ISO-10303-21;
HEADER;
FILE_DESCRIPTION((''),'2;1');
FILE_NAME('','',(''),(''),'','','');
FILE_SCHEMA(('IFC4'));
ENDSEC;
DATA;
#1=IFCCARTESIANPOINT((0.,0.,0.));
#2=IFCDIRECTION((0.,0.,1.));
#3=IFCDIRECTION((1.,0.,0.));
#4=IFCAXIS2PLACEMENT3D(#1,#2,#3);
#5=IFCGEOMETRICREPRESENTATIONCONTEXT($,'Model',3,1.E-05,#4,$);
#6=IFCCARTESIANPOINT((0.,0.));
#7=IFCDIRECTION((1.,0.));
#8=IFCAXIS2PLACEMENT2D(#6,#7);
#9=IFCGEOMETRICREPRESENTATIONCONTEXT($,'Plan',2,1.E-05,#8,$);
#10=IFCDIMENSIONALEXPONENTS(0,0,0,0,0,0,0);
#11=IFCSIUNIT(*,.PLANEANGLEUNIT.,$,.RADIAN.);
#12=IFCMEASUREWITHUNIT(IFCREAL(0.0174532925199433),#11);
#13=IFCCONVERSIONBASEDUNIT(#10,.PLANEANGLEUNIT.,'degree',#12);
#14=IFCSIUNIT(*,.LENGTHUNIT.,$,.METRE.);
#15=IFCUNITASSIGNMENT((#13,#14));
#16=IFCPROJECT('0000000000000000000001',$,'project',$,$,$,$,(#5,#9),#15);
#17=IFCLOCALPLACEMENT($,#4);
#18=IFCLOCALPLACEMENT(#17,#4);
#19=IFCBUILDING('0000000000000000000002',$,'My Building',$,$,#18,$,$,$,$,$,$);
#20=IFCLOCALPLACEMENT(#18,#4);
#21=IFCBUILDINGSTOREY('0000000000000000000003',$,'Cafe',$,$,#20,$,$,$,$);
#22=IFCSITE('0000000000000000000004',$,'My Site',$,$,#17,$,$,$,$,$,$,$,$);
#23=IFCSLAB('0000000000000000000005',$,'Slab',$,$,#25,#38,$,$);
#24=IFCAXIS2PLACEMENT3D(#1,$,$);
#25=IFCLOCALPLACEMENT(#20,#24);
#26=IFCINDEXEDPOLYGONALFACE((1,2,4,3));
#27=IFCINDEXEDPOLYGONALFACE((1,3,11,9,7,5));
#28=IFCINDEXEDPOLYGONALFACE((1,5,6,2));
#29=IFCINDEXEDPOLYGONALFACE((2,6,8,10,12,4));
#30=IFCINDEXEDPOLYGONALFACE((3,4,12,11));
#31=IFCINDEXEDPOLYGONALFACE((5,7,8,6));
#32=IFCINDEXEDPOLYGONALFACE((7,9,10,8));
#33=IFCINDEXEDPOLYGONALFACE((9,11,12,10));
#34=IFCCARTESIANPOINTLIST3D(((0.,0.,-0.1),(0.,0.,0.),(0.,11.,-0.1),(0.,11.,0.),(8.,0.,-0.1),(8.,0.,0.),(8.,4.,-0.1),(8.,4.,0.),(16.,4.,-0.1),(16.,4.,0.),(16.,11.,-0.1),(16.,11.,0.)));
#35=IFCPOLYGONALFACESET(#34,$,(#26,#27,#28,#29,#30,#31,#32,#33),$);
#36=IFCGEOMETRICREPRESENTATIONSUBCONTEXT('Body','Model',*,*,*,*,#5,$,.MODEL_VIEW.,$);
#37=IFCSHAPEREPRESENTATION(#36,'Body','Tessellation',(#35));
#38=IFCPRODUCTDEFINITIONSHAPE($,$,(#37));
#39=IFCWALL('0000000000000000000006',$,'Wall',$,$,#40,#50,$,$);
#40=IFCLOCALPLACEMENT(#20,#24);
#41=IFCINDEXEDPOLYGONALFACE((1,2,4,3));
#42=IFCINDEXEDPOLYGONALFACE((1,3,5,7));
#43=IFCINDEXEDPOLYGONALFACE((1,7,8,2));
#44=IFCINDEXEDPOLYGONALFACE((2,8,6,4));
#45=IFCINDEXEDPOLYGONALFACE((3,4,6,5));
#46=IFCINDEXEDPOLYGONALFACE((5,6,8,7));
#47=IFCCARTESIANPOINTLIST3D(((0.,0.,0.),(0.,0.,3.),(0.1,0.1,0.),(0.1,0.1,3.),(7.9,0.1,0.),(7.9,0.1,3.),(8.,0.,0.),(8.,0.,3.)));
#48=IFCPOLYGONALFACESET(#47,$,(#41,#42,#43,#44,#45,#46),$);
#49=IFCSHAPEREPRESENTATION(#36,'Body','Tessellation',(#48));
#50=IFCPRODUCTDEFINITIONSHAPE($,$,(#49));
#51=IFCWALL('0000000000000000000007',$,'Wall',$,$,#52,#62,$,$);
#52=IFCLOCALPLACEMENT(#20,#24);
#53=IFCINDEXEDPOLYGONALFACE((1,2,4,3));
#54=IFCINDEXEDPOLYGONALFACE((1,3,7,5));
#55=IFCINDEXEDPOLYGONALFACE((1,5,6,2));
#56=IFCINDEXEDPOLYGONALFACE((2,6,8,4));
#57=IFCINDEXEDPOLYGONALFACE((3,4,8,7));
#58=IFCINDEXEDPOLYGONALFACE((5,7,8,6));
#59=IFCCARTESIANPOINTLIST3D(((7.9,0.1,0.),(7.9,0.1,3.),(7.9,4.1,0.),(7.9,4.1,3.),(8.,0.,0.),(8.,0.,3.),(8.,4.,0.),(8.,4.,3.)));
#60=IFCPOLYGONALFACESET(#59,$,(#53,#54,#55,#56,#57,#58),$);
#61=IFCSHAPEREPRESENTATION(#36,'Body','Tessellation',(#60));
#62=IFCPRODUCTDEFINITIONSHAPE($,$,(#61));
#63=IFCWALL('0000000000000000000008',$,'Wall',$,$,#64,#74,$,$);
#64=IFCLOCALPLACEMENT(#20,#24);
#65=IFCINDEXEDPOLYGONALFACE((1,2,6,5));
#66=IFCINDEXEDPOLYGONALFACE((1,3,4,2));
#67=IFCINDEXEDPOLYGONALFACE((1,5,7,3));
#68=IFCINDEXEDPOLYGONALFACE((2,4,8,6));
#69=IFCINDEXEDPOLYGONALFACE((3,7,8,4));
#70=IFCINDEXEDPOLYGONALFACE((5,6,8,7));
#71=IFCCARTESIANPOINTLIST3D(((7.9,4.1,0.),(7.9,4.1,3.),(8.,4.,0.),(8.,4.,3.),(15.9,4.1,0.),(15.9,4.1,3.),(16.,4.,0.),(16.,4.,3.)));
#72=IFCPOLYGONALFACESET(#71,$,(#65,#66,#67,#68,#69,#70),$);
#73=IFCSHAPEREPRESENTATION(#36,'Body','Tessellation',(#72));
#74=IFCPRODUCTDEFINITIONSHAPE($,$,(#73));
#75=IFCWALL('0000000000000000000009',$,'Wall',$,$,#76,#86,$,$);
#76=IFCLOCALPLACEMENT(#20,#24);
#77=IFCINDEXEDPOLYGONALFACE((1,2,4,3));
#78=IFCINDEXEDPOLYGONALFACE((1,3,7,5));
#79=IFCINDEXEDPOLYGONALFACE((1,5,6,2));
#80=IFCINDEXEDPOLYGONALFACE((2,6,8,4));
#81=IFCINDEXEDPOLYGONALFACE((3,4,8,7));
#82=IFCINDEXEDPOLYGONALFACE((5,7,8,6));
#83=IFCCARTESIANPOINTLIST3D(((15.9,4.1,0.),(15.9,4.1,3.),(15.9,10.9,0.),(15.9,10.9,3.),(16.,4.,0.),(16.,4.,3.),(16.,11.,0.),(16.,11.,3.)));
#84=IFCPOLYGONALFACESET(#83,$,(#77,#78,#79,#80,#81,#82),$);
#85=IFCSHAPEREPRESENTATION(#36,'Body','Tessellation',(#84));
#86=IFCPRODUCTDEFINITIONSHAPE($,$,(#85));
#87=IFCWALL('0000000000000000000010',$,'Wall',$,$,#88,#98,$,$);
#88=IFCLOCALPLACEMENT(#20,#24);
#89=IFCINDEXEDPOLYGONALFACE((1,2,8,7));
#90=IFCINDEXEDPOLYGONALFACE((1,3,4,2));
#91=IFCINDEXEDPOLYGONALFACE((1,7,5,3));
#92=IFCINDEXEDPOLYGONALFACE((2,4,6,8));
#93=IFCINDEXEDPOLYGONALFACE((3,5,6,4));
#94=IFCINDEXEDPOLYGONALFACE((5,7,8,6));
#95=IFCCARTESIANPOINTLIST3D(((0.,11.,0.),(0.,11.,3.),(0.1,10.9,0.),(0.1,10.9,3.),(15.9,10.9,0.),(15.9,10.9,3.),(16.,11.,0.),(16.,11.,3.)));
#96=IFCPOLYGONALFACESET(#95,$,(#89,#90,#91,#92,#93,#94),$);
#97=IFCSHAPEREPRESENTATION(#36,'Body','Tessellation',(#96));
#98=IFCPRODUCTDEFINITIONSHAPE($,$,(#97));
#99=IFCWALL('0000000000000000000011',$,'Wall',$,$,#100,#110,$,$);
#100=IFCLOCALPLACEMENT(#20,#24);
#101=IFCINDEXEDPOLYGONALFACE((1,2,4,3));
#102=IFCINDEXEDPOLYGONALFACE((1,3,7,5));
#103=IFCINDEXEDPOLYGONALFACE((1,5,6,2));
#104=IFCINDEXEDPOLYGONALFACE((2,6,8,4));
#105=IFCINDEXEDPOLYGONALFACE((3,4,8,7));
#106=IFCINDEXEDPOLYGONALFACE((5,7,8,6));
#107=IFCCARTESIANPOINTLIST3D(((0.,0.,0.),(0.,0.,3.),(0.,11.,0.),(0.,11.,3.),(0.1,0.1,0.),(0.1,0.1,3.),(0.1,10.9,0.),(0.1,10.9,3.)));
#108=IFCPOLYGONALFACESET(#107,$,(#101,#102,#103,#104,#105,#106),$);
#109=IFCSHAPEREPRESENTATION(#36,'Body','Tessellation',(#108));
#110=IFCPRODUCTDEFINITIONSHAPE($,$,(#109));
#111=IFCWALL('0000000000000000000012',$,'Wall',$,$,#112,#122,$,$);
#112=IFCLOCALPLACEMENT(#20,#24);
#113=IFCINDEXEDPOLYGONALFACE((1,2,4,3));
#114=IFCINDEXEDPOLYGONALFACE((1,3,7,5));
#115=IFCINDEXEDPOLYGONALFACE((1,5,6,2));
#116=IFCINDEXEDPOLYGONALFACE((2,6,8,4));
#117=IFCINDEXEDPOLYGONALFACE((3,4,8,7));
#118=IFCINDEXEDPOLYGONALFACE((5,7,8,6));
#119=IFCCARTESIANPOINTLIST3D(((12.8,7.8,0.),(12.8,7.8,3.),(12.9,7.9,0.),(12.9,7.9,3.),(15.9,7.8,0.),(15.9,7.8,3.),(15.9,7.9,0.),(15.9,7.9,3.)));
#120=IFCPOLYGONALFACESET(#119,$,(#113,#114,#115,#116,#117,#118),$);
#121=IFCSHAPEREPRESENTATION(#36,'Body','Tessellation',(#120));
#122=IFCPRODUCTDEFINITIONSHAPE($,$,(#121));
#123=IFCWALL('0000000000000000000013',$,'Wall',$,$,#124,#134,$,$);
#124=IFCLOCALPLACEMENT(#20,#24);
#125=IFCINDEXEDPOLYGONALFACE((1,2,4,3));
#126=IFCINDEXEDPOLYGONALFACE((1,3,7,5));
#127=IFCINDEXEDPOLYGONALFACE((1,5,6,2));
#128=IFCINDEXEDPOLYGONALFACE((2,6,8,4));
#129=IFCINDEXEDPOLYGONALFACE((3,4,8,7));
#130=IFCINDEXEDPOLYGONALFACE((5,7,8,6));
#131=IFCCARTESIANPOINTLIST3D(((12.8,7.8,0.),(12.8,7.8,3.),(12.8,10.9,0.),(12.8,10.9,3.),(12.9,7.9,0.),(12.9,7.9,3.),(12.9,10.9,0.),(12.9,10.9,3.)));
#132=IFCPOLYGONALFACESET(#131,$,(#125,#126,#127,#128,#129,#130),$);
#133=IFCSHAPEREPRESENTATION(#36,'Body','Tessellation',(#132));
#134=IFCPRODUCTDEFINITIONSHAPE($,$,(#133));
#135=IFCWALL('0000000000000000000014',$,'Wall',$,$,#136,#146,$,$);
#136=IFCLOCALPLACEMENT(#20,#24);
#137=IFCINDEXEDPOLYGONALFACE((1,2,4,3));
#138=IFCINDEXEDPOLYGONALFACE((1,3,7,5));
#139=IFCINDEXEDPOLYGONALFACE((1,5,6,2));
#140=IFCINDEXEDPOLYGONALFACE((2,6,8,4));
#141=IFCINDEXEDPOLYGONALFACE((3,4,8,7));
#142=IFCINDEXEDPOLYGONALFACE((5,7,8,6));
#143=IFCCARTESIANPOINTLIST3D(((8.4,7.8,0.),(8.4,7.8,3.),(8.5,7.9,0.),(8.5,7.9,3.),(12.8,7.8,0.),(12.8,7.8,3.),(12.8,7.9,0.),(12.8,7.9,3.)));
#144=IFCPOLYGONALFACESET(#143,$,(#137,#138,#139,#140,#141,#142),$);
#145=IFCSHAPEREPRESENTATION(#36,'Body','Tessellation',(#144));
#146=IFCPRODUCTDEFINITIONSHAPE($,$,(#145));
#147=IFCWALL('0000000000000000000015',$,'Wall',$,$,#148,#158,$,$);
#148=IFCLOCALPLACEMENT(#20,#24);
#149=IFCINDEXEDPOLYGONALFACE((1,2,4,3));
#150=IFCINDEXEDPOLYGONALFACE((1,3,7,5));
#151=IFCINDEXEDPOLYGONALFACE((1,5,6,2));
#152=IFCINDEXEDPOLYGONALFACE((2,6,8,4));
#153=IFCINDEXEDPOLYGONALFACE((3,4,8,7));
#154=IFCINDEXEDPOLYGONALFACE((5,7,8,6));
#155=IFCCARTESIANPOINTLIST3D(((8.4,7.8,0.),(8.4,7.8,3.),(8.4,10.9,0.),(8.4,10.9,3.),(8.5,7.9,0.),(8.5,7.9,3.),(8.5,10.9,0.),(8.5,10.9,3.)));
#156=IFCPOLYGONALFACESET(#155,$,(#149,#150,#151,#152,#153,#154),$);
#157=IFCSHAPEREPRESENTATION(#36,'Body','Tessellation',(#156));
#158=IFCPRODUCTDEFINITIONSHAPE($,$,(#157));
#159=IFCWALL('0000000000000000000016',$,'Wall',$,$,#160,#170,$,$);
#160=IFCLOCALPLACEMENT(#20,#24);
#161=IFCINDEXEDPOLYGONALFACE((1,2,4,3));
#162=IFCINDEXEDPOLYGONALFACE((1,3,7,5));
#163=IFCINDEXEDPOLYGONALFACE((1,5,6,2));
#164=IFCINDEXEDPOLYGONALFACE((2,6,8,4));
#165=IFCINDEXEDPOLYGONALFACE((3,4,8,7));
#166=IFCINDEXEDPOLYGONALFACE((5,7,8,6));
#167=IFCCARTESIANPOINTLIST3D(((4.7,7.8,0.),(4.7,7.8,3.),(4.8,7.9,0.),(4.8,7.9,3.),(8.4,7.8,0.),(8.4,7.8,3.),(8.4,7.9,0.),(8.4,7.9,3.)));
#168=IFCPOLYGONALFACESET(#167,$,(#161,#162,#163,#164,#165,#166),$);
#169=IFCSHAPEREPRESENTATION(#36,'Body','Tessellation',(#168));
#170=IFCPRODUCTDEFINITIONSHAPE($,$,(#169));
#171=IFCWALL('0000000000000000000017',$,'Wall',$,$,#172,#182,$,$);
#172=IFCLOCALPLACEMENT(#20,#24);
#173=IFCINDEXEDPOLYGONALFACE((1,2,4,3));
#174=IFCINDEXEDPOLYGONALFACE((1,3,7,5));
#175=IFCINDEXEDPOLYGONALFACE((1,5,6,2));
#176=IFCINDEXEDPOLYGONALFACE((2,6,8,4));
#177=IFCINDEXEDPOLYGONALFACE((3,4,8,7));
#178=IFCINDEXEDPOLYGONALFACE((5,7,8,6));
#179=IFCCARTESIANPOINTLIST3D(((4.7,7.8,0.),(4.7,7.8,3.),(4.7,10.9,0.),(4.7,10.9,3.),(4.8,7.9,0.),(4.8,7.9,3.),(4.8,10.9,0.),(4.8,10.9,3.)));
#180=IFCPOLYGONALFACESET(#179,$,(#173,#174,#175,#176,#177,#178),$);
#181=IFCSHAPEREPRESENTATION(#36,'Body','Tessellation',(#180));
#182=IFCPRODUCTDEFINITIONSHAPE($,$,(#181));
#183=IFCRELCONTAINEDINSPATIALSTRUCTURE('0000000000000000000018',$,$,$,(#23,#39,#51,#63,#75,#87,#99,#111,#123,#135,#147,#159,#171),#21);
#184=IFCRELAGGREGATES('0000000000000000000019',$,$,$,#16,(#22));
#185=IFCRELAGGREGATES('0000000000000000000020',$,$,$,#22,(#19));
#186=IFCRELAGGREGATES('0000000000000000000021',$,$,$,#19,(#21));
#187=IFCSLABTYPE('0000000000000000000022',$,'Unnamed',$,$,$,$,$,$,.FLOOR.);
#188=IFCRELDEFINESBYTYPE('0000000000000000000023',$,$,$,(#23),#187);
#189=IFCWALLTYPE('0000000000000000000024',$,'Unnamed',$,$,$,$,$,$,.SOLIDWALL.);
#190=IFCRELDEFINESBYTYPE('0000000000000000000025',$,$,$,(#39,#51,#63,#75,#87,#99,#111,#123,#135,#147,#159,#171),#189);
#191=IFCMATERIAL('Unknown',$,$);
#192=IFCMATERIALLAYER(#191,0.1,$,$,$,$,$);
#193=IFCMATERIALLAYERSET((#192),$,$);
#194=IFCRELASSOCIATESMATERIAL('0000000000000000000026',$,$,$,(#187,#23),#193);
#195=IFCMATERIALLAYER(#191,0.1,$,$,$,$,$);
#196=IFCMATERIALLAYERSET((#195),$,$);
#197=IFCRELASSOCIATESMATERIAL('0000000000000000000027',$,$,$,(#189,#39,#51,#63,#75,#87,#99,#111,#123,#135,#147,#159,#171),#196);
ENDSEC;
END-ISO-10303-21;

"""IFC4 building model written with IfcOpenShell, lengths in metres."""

from ifc_helpers import new_model, entity, si_unit, converted_unit, frame, origin_with_axes, origin_2d_with_axis, place, context, subcontext, project, spatial, line, indexed_curve, outline, extrude, material, layer, layer_set, layer_usage, type_object, element, save


model = new_model("IFC4")

# Units and contexts
model_context = context("Model", 3, precision=1e-05, world=origin_with_axes())
plan_context = context("Plan", 2, precision=1e-05, world=origin_2d_with_axis())
body_context = subcontext(model_context, "Body", "Model", "MODEL_VIEW")
ifc_project = project(units=[converted_unit("PLANEANGLEUNIT", "degree", entity("IfcReal", 0.0174532925199433), si_unit("PLANEANGLEUNIT", "RADIAN"), dimensions=[0, 0, 0, 0, 0, 0, 0]), si_unit("LENGTHUNIT", "METRE")], contexts=[model_context, plan_context])

# Site, building, storey
site_placement = place(None, origin_with_axes())
site = spatial("IfcSite", under=ifc_project, at=site_placement, Name="My Site")
building_placement = place(site_placement, origin_with_axes())
building = spatial("IfcBuilding", under=site, at=building_placement, Name="My Building")
storey_placement = place(building_placement, origin_with_axes())
storey = spatial("IfcBuildingStorey", under=building, at=storey_placement, Name="Cafe")

# Slab
ifc_material = material(Name="Unknown")
ifc_layer_1 = layer(ifc_material, 0.1)
ifc_layer_set_1 = layer_set([ifc_layer_1])
ifc_layer_usage_1 = layer_usage(ifc_layer_set_1, "AXIS3", "POSITIVE", -0.1)
slab_type = type_object("IfcSlabType", Name="Unnamed", PredefinedType="FLOOR", material=ifc_layer_set_1)
slab_placement = place(storey_placement, frame((0.0, 0.0, 0.0), z_axis=(0.0, 0.0, 1.0), x_axis=(1.0, 0.0, 0.0)))
element("IfcSlab", 1, at=slab_placement, inside=storey, type_object=slab_type, material=ifc_layer_usage_1, Name="Slab", context=body_context, shape_type="SweptSolid", body=[
    extrude(outline(indexed_curve([(0.0, 0.0), (8.0, 0.0), (8.0, 4.0), (16.0, 4.0), (16.0, 11.0), (0.0, 11.0), (0.0, 0.0), (0.0, 0.0)])), frame((0.0, 0.0, -0.1), z_axis=(0.0, 0.0, 1.0), x_axis=(1.0, 0.0, 0.0)), (0.0, 0.0, 1.0), 0.1),
])

# Walls
ifc_layer_2 = layer(ifc_material, 0.1)
ifc_layer_set_2 = layer_set([ifc_layer_2])
ifc_layer_usage_2 = layer_usage(ifc_layer_set_2, "AXIS2", "POSITIVE", 0.0)
wall_type = type_object("IfcWallType", Name="Unnamed", PredefinedType="SOLIDWALL", material=ifc_layer_set_2)
wall_1_placement = place(storey_placement, frame((0.0, 0.0, 0.0), z_axis=(0.0, 0.0, 1.0), x_axis=(1.0, 0.0, 0.0)))
element("IfcWall", 2, at=wall_1_placement, inside=storey, type_object=wall_type, material=ifc_layer_usage_2, Name="Wall", context=body_context, shape_type="SweptSolid", body=[
    extrude(outline(indexed_curve([(0.0, 0.0), (0.1, 0.1), (7.9, 0.1), (8.0, 0.0)], segments=[line(1, 2, 3, 4, 1)])), origin_with_axes(), (0.0, 0.0, 1.0), 3.0),
])
ifc_layer_usage_3 = layer_usage(ifc_layer_set_2, "AXIS2", "POSITIVE", 0.0)
wall_2_placement = place(storey_placement, frame((8.0, 0.0, 0.0), z_axis=(0.0, 0.0, 1.0), x_axis=(0.0, 1.0, 0.0)))
element("IfcWall", 3, at=wall_2_placement, inside=storey, type_object=wall_type, material=ifc_layer_usage_3, Name="Wall", context=body_context, shape_type="SweptSolid", body=[
    extrude(outline(indexed_curve([(0.0, 0.0), (0.1, 0.1), (4.1, 0.1), (4.0, 0.0)], segments=[line(1, 2, 3, 4, 1)])), origin_with_axes(), (0.0, 0.0, 1.0), 3.0),
])
ifc_layer_usage_4 = layer_usage(ifc_layer_set_2, "AXIS2", "POSITIVE", 0.0)
wall_3_placement = place(storey_placement, frame((8.0, 4.0, 0.0), z_axis=(0.0, 0.0, 1.0), x_axis=(1.0, 0.0, 0.0)))
element("IfcWall", 4, at=wall_3_placement, inside=storey, type_object=wall_type, material=ifc_layer_usage_4, Name="Wall", context=body_context, shape_type="SweptSolid", body=[
    extrude(outline(indexed_curve([(0.0, 0.0), (-0.1, 0.1), (7.9, 0.1), (8.0, 0.0)], segments=[line(1, 2, 3, 4, 1)])), origin_with_axes(), (0.0, 0.0, 1.0), 3.0),
])
ifc_layer_usage_5 = layer_usage(ifc_layer_set_2, "AXIS2", "POSITIVE", 0.0)
wall_4_placement = place(storey_placement, frame((16.0, 4.0, 0.0), z_axis=(0.0, 0.0, 1.0), x_axis=(0.0, 1.0, 0.0)))
element("IfcWall", 5, at=wall_4_placement, inside=storey, type_object=wall_type, material=ifc_layer_usage_5, Name="Wall", context=body_context, shape_type="SweptSolid", body=[
    extrude(outline(indexed_curve([(0.0, 0.0), (0.1, 0.1), (6.9, 0.1), (7.0, 0.0)], segments=[line(1, 2, 3, 4, 1)])), origin_with_axes(), (0.0, 0.0, 1.0), 3.0),
])
ifc_layer_usage_6 = layer_usage(ifc_layer_set_2, "AXIS2", "POSITIVE", 0.0)
wall_5_placement = place(storey_placement, frame((16.0, 11.0, 0.0), z_axis=(0.0, 0.0, 1.0), x_axis=(-1.0, 0.0, 0.0)))
element("IfcWall", 6, at=wall_5_placement, inside=storey, type_object=wall_type, material=ifc_layer_usage_6, Name="Wall", context=body_context, shape_type="SweptSolid", body=[
    extrude(outline(indexed_curve([(0.0, 0.0), (0.1, 0.1), (15.9, 0.1), (16.0, 0.0)], segments=[line(1, 2, 3, 4, 1)])), origin_with_axes(), (0.0, 0.0, 1.0), 3.0),
])
ifc_layer_usage_7 = layer_usage(ifc_layer_set_2, "AXIS2", "POSITIVE", 0.0)
wall_6_placement = place(storey_placement, frame((0.0, 11.0, 0.0), z_axis=(0.0, 0.0, 1.0), x_axis=(0.0, -1.0, 0.0)))
element("IfcWall", 7, at=wall_6_placement, inside=storey, type_object=wall_type, material=ifc_layer_usage_7, Name="Wall", context=body_context, shape_type="SweptSolid", body=[
    extrude(outline(indexed_curve([(0.0, 0.0), (0.1, 0.1), (10.9, 0.1), (11.0, 0.0)], segments=[line(1, 2, 3, 4, 1)])), origin_with_axes(), (0.0, 0.0, 1.0), 3.0),
])
ifc_layer_usage_8 = layer_usage(ifc_layer_set_2, "AXIS2", "POSITIVE", 0.0)
wall_7_placement = place(storey_placement, frame((15.9, 7.9, 0.0), z_axis=(0.0, 0.0, 1.0), x_axis=(-1.0, 0.0, 0.0)))
element("IfcWall", 8, at=wall_7_placement, inside=storey, type_object=wall_type, material=ifc_layer_usage_8, Name="Wall", context=body_context, shape_type="SweptSolid", body=[
    extrude(outline(indexed_curve([(0.0, 0.0), (0.0, 0.1), (3.1, 0.1), (3.0, 0.0)], segments=[line(1, 2, 3, 4, 1)])), origin_with_axes(), (0.0, 0.0, 1.0), 3.0),
])
ifc_layer_usage_9 = layer_usage(ifc_layer_set_2, "AXIS2", "POSITIVE", 0.0)
wall_8_placement = place(storey_placement, frame((12.9, 7.9, 0.0), z_axis=(0.0, 0.0, 1.0), x_axis=(0.0, 1.0, 0.0)))
element("IfcWall", 9, at=wall_8_placement, inside=storey, type_object=wall_type, material=ifc_layer_usage_9, Name="Wall", context=body_context, shape_type="SweptSolid", body=[
    extrude(outline(indexed_curve([(0.0, 0.0), (-0.1, 0.1), (3.0, 0.1), (3.0, 0.0)], segments=[line(1, 2, 3, 4, 1)])), origin_with_axes(), (0.0, 0.0, 1.0), 3.0),
])
ifc_layer_usage_10 = layer_usage(ifc_layer_set_2, "AXIS2", "POSITIVE", 0.0)
wall_9_placement = place(storey_placement, frame((12.8, 7.9, 0.0), z_axis=(0.0, 0.0, 1.0), x_axis=(-1.0, 0.0, 0.0)))
element("IfcWall", 10, at=wall_9_placement, inside=storey, type_object=wall_type, material=ifc_layer_usage_10, Name="Wall", context=body_context, shape_type="SweptSolid", body=[
    extrude(outline(indexed_curve([(0.0, 0.0), (0.0, 0.1), (4.4, 0.1), (4.3, 0.0)], segments=[line(1, 2, 3, 4, 1)])), origin_with_axes(), (0.0, 0.0, 1.0), 3.0),
])
ifc_layer_usage_11 = layer_usage(ifc_layer_set_2, "AXIS2", "POSITIVE", 0.0)
wall_10_placement = place(storey_placement, frame((8.5, 7.9, 0.0), z_axis=(0.0, 0.0, 1.0), x_axis=(0.0, 1.0, 0.0)))
element("IfcWall", 11, at=wall_10_placement, inside=storey, type_object=wall_type, material=ifc_layer_usage_11, Name="Wall", context=body_context, shape_type="SweptSolid", body=[
    extrude(outline(indexed_curve([(0.0, 0.0), (-0.1, 0.1), (3.0, 0.1), (3.0, 0.0)], segments=[line(1, 2, 3, 4, 1)])), origin_with_axes(), (0.0, 0.0, 1.0), 3.0),
])
ifc_layer_usage_12 = layer_usage(ifc_layer_set_2, "AXIS2", "POSITIVE", 0.0)
wall_11_placement = place(storey_placement, frame((8.4, 7.9, 0.0), z_axis=(0.0, 0.0, 1.0), x_axis=(-1.0, 0.0, 0.0)))
element("IfcWall", 12, at=wall_11_placement, inside=storey, type_object=wall_type, material=ifc_layer_usage_12, Name="Wall", context=body_context, shape_type="SweptSolid", body=[
    extrude(outline(indexed_curve([(0.0, 0.0), (0.0, 0.1), (3.7, 0.1), (3.6, 0.0)], segments=[line(1, 2, 3, 4, 1)])), origin_with_axes(), (0.0, 0.0, 1.0), 3.0),
])
ifc_layer_usage_13 = layer_usage(ifc_layer_set_2, "AXIS2", "POSITIVE", 0.0)
wall_12_placement = place(storey_placement, frame((4.8, 7.9, 0.0), z_axis=(0.0, 0.0, 1.0), x_axis=(0.0, 1.0, 0.0)))
element("IfcWall", 13, at=wall_12_placement, inside=storey, type_object=wall_type, material=ifc_layer_usage_13, Name="Wall", context=body_context, shape_type="SweptSolid", body=[
    extrude(outline(indexed_curve([(0.0, 0.0), (-0.1, 0.1), (3.0, 0.1), (3.0, 0.0)], segments=[line(1, 2, 3, 4, 1)])), origin_with_axes(), (0.0, 0.0, 1.0), 3.0),
])

save(model, "model.ifc")
